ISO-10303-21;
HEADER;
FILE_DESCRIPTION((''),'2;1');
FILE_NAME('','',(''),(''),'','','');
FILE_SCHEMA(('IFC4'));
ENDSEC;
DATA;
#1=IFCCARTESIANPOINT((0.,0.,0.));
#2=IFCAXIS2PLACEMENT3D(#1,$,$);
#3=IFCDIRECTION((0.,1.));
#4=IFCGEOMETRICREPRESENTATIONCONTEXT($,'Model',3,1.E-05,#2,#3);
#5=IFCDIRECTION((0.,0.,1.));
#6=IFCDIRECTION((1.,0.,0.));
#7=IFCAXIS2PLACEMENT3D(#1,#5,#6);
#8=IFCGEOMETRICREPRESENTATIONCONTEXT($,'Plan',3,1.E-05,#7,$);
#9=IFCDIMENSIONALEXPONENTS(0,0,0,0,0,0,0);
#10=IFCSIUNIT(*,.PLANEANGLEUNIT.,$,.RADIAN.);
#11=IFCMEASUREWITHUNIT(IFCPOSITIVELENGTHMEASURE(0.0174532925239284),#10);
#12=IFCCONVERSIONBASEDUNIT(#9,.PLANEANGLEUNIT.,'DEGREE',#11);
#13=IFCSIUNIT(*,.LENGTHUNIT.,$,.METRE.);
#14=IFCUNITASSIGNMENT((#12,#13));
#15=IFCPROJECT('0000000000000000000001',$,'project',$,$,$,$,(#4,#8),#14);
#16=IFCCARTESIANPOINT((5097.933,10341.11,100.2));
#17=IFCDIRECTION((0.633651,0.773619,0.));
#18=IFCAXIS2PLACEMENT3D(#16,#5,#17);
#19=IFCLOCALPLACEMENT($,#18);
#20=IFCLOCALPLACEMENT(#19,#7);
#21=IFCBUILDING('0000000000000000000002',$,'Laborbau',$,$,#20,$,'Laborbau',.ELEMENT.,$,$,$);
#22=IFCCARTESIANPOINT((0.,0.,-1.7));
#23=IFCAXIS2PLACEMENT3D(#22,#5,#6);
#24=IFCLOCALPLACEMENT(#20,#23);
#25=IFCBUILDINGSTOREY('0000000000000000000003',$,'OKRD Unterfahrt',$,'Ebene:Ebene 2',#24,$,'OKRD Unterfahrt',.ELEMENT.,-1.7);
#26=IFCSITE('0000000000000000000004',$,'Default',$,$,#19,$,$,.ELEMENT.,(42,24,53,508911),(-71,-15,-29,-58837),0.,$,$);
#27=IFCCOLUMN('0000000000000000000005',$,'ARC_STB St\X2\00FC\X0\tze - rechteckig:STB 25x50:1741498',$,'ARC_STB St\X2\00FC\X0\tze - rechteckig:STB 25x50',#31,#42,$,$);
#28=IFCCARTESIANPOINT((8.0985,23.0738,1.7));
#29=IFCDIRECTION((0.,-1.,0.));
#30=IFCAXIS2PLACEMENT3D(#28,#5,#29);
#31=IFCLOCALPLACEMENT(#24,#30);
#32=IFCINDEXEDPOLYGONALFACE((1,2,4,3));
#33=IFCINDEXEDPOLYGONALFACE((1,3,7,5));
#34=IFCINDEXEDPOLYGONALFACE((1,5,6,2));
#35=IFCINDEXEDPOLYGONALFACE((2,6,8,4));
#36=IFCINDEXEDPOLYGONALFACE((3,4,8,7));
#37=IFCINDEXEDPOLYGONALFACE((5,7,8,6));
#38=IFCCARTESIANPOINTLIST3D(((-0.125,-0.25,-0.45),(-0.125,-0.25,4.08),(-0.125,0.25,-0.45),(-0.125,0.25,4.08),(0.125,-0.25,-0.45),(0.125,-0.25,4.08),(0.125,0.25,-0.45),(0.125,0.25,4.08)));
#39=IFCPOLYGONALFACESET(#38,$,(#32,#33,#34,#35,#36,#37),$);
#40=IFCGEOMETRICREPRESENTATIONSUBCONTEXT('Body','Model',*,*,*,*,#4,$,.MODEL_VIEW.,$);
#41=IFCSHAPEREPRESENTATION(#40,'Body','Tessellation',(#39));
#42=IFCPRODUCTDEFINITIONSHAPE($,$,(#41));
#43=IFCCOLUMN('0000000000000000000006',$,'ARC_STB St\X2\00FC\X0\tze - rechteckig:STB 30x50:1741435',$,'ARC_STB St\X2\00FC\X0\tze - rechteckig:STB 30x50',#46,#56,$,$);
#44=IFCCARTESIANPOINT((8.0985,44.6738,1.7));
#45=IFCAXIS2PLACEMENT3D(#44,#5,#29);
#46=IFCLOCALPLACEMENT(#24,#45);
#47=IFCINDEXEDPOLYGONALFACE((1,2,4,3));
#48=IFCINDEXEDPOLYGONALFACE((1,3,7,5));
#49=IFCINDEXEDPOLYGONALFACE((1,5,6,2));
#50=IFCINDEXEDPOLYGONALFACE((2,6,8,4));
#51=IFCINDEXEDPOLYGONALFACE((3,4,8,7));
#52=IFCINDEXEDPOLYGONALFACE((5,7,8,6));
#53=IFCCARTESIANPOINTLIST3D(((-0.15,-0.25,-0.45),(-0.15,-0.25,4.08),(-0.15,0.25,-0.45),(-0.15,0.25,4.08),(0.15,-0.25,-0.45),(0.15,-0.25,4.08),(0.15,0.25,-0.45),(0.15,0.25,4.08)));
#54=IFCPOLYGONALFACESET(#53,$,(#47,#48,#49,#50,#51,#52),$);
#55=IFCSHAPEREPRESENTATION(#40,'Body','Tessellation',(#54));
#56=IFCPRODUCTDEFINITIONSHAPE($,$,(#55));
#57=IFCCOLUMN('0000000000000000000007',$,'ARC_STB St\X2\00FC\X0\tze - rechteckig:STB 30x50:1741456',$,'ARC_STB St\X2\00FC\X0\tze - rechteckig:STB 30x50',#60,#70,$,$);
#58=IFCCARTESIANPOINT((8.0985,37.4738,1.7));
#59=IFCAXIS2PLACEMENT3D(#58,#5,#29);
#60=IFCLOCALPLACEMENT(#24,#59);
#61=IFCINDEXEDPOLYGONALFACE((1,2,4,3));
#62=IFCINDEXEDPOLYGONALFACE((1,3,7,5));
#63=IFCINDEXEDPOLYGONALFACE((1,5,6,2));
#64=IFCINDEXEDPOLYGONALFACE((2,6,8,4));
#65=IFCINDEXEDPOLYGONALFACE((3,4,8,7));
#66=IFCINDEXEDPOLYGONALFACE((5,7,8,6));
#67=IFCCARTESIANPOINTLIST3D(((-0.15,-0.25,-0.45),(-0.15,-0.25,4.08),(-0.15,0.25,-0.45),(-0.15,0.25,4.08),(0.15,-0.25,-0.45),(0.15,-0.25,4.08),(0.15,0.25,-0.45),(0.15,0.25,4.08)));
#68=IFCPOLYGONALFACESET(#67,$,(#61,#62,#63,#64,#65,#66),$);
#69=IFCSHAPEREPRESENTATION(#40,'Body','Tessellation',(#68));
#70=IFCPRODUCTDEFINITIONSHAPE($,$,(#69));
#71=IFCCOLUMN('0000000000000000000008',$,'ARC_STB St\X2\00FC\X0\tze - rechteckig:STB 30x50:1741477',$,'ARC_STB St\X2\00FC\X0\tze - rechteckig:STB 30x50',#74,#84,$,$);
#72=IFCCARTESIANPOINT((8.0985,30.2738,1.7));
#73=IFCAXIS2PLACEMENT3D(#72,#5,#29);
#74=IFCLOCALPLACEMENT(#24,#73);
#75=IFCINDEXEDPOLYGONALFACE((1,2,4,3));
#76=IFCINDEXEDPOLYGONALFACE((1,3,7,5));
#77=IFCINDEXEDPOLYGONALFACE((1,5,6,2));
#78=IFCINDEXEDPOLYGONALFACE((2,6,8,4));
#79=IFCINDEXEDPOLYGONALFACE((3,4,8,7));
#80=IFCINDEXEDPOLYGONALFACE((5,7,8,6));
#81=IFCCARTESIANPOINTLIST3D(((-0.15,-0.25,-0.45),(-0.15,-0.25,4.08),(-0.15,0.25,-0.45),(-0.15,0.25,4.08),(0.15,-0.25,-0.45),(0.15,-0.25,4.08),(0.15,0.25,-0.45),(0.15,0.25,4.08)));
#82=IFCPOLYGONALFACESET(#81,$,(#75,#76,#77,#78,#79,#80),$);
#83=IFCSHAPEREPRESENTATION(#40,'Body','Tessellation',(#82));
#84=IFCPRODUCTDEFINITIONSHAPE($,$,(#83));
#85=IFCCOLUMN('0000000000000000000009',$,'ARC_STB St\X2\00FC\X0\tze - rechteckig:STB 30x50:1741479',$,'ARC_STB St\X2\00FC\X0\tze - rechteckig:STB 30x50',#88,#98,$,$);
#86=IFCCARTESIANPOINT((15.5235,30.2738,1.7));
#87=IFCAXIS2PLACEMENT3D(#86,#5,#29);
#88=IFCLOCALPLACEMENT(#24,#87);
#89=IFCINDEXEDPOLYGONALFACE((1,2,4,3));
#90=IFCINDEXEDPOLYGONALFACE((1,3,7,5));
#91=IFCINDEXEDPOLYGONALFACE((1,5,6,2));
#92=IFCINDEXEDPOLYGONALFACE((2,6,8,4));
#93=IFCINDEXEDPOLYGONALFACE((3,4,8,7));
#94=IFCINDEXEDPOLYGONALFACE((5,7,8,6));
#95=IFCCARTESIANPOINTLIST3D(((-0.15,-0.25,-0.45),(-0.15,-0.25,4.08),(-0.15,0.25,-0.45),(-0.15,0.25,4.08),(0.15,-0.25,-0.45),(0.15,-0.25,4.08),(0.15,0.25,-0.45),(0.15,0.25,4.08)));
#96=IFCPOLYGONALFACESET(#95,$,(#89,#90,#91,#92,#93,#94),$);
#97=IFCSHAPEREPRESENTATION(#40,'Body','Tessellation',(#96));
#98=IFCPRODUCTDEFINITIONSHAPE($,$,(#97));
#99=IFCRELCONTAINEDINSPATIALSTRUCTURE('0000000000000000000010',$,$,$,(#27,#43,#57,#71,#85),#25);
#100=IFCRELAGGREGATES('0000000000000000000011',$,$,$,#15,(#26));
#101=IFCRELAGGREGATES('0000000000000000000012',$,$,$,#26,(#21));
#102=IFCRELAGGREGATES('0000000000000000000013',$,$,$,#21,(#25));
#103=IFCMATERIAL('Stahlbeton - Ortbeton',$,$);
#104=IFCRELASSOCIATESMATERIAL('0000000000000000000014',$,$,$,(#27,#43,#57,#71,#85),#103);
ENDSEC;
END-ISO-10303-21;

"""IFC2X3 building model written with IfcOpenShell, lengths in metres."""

from ifc_helpers import new_model, entity, si_unit, converted_unit, direction, frame, origin, origin_with_axes, origin_2d_with_axis, place, context, subcontext, project, spatial, rectangle, extrude, source, transform, mapped, material, element, save


model = new_model("IFC2X3")

# Units and contexts
model_context = context("Model", 3, precision=1e-05, world=origin(), true_north=direction((0.0, 1.0)))
plan_context = context("Plan", 3, precision=1e-05, world=origin_with_axes())
body_context = subcontext(model_context, "Body", "Model", "MODEL_VIEW")
ifc_project = project(units=[converted_unit("PLANEANGLEUNIT", "DEGREE", entity("IfcPositiveLengthMeasure", 0.0174532925239284), si_unit("PLANEANGLEUNIT", "RADIAN"), dimensions=[0, 0, 0, 0, 0, 0, 0]), si_unit("LENGTHUNIT", "METRE")], contexts=[model_context, plan_context])

# Site, building, storey
site_placement = place(None, frame((5097.933, 10341.11, 100.2), z_axis=(0.0, 0.0, 1.0), x_axis=(0.633651, 0.773619, 0.0)))
site = spatial("IfcSite", under=ifc_project, at=site_placement, Name="Default", CompositionType="ELEMENT", RefLatitude=(42, 24, 53, 508911), RefLongitude=(-71, -15, -29, -58837), RefElevation=0.0)
building_placement = place(site_placement, origin_with_axes())
building = spatial("IfcBuilding", under=site, at=building_placement, Name="Laborbau", LongName="Laborbau", CompositionType="ELEMENT")
storey_placement = place(building_placement, frame((0.0, 0.0, -1.7), z_axis=(0.0, 0.0, 1.0), x_axis=(1.0, 0.0, 0.0)))
storey = spatial("IfcBuildingStorey", under=building, at=storey_placement, Name="OKRD Unterfahrt", ObjectType="Ebene:Ebene 2", LongName="OKRD Unterfahrt", CompositionType="ELEMENT", Elevation=-1.7)

# Columns
ifc_material_1 = material(Name="Stahlbeton - Ortbeton")
shared_shape_1 = source(origin(), body_context, "Body", "SweptSolid", [
    extrude(rectangle(XDim=0.5, YDim=0.25, at=origin_2d_with_axis()), frame((0.0, 0.0, -0.45), z_axis=(0.0, 0.0, 1.0), x_axis=(0.0, -1.0, 0.0)), (0.0, 0.0, 1.0), 4.53),
])
column_placement = place(storey_placement, frame((8.0985, 23.0738, 1.7), z_axis=(0.0, 0.0, 1.0), x_axis=(0.0, -1.0, 0.0)))
element("IfcColumn", 1, at=column_placement, inside=storey, material=ifc_material_1, Name="ARC_STB Stütze - rechteckig:STB 25x50:1741498", ObjectType="ARC_STB Stütze - rechteckig:STB 25x50", context=body_context, shape_type="MappedRepresentation", body=[
    mapped(shared_shape_1, transform((0.0, 0.0, 0.0), scale=1.0)),
])
shared_shape_2 = source(origin(), body_context, "Body", "SweptSolid", [
    extrude(rectangle(XDim=0.5, YDim=0.3, at=origin_2d_with_axis()), frame((0.0, 0.0, -0.45), z_axis=(0.0, 0.0, 1.0), x_axis=(0.0, -1.0, 0.0)), (0.0, 0.0, 1.0), 4.53),
])
for number, where, z_axis, x_axis, name in (
    (2, (8.0985, 44.6738, 1.7), (0.0, 0.0, 1.0), (0.0, -1.0, 0.0), "ARC_STB Stütze - rechteckig:STB 30x50:1741435"),
    (3, (8.0985, 37.4738, 1.7), (0.0, 0.0, 1.0), (0.0, -1.0, 0.0), "ARC_STB Stütze - rechteckig:STB 30x50:1741456"),
    (4, (8.0985, 30.2738, 1.7), (0.0, 0.0, 1.0), (0.0, -1.0, 0.0), "ARC_STB Stütze - rechteckig:STB 30x50:1741477"),
    (5, (15.5235, 30.2738, 1.7), (0.0, 0.0, 1.0), (0.0, -1.0, 0.0), "ARC_STB Stütze - rechteckig:STB 30x50:1741479"),
):
    element("IfcColumn", number, at=place(storey_placement, frame(where, z_axis=z_axis, x_axis=x_axis)), inside=storey, material=ifc_material_1, Name=name, ObjectType="ARC_STB Stütze - rechteckig:STB 30x50", context=body_context, shape_type="MappedRepresentation", body=[
        mapped(shared_shape_2, transform((0.0, 0.0, 0.0), scale=1.0)),
    ])

save(model, "model.ifc")
